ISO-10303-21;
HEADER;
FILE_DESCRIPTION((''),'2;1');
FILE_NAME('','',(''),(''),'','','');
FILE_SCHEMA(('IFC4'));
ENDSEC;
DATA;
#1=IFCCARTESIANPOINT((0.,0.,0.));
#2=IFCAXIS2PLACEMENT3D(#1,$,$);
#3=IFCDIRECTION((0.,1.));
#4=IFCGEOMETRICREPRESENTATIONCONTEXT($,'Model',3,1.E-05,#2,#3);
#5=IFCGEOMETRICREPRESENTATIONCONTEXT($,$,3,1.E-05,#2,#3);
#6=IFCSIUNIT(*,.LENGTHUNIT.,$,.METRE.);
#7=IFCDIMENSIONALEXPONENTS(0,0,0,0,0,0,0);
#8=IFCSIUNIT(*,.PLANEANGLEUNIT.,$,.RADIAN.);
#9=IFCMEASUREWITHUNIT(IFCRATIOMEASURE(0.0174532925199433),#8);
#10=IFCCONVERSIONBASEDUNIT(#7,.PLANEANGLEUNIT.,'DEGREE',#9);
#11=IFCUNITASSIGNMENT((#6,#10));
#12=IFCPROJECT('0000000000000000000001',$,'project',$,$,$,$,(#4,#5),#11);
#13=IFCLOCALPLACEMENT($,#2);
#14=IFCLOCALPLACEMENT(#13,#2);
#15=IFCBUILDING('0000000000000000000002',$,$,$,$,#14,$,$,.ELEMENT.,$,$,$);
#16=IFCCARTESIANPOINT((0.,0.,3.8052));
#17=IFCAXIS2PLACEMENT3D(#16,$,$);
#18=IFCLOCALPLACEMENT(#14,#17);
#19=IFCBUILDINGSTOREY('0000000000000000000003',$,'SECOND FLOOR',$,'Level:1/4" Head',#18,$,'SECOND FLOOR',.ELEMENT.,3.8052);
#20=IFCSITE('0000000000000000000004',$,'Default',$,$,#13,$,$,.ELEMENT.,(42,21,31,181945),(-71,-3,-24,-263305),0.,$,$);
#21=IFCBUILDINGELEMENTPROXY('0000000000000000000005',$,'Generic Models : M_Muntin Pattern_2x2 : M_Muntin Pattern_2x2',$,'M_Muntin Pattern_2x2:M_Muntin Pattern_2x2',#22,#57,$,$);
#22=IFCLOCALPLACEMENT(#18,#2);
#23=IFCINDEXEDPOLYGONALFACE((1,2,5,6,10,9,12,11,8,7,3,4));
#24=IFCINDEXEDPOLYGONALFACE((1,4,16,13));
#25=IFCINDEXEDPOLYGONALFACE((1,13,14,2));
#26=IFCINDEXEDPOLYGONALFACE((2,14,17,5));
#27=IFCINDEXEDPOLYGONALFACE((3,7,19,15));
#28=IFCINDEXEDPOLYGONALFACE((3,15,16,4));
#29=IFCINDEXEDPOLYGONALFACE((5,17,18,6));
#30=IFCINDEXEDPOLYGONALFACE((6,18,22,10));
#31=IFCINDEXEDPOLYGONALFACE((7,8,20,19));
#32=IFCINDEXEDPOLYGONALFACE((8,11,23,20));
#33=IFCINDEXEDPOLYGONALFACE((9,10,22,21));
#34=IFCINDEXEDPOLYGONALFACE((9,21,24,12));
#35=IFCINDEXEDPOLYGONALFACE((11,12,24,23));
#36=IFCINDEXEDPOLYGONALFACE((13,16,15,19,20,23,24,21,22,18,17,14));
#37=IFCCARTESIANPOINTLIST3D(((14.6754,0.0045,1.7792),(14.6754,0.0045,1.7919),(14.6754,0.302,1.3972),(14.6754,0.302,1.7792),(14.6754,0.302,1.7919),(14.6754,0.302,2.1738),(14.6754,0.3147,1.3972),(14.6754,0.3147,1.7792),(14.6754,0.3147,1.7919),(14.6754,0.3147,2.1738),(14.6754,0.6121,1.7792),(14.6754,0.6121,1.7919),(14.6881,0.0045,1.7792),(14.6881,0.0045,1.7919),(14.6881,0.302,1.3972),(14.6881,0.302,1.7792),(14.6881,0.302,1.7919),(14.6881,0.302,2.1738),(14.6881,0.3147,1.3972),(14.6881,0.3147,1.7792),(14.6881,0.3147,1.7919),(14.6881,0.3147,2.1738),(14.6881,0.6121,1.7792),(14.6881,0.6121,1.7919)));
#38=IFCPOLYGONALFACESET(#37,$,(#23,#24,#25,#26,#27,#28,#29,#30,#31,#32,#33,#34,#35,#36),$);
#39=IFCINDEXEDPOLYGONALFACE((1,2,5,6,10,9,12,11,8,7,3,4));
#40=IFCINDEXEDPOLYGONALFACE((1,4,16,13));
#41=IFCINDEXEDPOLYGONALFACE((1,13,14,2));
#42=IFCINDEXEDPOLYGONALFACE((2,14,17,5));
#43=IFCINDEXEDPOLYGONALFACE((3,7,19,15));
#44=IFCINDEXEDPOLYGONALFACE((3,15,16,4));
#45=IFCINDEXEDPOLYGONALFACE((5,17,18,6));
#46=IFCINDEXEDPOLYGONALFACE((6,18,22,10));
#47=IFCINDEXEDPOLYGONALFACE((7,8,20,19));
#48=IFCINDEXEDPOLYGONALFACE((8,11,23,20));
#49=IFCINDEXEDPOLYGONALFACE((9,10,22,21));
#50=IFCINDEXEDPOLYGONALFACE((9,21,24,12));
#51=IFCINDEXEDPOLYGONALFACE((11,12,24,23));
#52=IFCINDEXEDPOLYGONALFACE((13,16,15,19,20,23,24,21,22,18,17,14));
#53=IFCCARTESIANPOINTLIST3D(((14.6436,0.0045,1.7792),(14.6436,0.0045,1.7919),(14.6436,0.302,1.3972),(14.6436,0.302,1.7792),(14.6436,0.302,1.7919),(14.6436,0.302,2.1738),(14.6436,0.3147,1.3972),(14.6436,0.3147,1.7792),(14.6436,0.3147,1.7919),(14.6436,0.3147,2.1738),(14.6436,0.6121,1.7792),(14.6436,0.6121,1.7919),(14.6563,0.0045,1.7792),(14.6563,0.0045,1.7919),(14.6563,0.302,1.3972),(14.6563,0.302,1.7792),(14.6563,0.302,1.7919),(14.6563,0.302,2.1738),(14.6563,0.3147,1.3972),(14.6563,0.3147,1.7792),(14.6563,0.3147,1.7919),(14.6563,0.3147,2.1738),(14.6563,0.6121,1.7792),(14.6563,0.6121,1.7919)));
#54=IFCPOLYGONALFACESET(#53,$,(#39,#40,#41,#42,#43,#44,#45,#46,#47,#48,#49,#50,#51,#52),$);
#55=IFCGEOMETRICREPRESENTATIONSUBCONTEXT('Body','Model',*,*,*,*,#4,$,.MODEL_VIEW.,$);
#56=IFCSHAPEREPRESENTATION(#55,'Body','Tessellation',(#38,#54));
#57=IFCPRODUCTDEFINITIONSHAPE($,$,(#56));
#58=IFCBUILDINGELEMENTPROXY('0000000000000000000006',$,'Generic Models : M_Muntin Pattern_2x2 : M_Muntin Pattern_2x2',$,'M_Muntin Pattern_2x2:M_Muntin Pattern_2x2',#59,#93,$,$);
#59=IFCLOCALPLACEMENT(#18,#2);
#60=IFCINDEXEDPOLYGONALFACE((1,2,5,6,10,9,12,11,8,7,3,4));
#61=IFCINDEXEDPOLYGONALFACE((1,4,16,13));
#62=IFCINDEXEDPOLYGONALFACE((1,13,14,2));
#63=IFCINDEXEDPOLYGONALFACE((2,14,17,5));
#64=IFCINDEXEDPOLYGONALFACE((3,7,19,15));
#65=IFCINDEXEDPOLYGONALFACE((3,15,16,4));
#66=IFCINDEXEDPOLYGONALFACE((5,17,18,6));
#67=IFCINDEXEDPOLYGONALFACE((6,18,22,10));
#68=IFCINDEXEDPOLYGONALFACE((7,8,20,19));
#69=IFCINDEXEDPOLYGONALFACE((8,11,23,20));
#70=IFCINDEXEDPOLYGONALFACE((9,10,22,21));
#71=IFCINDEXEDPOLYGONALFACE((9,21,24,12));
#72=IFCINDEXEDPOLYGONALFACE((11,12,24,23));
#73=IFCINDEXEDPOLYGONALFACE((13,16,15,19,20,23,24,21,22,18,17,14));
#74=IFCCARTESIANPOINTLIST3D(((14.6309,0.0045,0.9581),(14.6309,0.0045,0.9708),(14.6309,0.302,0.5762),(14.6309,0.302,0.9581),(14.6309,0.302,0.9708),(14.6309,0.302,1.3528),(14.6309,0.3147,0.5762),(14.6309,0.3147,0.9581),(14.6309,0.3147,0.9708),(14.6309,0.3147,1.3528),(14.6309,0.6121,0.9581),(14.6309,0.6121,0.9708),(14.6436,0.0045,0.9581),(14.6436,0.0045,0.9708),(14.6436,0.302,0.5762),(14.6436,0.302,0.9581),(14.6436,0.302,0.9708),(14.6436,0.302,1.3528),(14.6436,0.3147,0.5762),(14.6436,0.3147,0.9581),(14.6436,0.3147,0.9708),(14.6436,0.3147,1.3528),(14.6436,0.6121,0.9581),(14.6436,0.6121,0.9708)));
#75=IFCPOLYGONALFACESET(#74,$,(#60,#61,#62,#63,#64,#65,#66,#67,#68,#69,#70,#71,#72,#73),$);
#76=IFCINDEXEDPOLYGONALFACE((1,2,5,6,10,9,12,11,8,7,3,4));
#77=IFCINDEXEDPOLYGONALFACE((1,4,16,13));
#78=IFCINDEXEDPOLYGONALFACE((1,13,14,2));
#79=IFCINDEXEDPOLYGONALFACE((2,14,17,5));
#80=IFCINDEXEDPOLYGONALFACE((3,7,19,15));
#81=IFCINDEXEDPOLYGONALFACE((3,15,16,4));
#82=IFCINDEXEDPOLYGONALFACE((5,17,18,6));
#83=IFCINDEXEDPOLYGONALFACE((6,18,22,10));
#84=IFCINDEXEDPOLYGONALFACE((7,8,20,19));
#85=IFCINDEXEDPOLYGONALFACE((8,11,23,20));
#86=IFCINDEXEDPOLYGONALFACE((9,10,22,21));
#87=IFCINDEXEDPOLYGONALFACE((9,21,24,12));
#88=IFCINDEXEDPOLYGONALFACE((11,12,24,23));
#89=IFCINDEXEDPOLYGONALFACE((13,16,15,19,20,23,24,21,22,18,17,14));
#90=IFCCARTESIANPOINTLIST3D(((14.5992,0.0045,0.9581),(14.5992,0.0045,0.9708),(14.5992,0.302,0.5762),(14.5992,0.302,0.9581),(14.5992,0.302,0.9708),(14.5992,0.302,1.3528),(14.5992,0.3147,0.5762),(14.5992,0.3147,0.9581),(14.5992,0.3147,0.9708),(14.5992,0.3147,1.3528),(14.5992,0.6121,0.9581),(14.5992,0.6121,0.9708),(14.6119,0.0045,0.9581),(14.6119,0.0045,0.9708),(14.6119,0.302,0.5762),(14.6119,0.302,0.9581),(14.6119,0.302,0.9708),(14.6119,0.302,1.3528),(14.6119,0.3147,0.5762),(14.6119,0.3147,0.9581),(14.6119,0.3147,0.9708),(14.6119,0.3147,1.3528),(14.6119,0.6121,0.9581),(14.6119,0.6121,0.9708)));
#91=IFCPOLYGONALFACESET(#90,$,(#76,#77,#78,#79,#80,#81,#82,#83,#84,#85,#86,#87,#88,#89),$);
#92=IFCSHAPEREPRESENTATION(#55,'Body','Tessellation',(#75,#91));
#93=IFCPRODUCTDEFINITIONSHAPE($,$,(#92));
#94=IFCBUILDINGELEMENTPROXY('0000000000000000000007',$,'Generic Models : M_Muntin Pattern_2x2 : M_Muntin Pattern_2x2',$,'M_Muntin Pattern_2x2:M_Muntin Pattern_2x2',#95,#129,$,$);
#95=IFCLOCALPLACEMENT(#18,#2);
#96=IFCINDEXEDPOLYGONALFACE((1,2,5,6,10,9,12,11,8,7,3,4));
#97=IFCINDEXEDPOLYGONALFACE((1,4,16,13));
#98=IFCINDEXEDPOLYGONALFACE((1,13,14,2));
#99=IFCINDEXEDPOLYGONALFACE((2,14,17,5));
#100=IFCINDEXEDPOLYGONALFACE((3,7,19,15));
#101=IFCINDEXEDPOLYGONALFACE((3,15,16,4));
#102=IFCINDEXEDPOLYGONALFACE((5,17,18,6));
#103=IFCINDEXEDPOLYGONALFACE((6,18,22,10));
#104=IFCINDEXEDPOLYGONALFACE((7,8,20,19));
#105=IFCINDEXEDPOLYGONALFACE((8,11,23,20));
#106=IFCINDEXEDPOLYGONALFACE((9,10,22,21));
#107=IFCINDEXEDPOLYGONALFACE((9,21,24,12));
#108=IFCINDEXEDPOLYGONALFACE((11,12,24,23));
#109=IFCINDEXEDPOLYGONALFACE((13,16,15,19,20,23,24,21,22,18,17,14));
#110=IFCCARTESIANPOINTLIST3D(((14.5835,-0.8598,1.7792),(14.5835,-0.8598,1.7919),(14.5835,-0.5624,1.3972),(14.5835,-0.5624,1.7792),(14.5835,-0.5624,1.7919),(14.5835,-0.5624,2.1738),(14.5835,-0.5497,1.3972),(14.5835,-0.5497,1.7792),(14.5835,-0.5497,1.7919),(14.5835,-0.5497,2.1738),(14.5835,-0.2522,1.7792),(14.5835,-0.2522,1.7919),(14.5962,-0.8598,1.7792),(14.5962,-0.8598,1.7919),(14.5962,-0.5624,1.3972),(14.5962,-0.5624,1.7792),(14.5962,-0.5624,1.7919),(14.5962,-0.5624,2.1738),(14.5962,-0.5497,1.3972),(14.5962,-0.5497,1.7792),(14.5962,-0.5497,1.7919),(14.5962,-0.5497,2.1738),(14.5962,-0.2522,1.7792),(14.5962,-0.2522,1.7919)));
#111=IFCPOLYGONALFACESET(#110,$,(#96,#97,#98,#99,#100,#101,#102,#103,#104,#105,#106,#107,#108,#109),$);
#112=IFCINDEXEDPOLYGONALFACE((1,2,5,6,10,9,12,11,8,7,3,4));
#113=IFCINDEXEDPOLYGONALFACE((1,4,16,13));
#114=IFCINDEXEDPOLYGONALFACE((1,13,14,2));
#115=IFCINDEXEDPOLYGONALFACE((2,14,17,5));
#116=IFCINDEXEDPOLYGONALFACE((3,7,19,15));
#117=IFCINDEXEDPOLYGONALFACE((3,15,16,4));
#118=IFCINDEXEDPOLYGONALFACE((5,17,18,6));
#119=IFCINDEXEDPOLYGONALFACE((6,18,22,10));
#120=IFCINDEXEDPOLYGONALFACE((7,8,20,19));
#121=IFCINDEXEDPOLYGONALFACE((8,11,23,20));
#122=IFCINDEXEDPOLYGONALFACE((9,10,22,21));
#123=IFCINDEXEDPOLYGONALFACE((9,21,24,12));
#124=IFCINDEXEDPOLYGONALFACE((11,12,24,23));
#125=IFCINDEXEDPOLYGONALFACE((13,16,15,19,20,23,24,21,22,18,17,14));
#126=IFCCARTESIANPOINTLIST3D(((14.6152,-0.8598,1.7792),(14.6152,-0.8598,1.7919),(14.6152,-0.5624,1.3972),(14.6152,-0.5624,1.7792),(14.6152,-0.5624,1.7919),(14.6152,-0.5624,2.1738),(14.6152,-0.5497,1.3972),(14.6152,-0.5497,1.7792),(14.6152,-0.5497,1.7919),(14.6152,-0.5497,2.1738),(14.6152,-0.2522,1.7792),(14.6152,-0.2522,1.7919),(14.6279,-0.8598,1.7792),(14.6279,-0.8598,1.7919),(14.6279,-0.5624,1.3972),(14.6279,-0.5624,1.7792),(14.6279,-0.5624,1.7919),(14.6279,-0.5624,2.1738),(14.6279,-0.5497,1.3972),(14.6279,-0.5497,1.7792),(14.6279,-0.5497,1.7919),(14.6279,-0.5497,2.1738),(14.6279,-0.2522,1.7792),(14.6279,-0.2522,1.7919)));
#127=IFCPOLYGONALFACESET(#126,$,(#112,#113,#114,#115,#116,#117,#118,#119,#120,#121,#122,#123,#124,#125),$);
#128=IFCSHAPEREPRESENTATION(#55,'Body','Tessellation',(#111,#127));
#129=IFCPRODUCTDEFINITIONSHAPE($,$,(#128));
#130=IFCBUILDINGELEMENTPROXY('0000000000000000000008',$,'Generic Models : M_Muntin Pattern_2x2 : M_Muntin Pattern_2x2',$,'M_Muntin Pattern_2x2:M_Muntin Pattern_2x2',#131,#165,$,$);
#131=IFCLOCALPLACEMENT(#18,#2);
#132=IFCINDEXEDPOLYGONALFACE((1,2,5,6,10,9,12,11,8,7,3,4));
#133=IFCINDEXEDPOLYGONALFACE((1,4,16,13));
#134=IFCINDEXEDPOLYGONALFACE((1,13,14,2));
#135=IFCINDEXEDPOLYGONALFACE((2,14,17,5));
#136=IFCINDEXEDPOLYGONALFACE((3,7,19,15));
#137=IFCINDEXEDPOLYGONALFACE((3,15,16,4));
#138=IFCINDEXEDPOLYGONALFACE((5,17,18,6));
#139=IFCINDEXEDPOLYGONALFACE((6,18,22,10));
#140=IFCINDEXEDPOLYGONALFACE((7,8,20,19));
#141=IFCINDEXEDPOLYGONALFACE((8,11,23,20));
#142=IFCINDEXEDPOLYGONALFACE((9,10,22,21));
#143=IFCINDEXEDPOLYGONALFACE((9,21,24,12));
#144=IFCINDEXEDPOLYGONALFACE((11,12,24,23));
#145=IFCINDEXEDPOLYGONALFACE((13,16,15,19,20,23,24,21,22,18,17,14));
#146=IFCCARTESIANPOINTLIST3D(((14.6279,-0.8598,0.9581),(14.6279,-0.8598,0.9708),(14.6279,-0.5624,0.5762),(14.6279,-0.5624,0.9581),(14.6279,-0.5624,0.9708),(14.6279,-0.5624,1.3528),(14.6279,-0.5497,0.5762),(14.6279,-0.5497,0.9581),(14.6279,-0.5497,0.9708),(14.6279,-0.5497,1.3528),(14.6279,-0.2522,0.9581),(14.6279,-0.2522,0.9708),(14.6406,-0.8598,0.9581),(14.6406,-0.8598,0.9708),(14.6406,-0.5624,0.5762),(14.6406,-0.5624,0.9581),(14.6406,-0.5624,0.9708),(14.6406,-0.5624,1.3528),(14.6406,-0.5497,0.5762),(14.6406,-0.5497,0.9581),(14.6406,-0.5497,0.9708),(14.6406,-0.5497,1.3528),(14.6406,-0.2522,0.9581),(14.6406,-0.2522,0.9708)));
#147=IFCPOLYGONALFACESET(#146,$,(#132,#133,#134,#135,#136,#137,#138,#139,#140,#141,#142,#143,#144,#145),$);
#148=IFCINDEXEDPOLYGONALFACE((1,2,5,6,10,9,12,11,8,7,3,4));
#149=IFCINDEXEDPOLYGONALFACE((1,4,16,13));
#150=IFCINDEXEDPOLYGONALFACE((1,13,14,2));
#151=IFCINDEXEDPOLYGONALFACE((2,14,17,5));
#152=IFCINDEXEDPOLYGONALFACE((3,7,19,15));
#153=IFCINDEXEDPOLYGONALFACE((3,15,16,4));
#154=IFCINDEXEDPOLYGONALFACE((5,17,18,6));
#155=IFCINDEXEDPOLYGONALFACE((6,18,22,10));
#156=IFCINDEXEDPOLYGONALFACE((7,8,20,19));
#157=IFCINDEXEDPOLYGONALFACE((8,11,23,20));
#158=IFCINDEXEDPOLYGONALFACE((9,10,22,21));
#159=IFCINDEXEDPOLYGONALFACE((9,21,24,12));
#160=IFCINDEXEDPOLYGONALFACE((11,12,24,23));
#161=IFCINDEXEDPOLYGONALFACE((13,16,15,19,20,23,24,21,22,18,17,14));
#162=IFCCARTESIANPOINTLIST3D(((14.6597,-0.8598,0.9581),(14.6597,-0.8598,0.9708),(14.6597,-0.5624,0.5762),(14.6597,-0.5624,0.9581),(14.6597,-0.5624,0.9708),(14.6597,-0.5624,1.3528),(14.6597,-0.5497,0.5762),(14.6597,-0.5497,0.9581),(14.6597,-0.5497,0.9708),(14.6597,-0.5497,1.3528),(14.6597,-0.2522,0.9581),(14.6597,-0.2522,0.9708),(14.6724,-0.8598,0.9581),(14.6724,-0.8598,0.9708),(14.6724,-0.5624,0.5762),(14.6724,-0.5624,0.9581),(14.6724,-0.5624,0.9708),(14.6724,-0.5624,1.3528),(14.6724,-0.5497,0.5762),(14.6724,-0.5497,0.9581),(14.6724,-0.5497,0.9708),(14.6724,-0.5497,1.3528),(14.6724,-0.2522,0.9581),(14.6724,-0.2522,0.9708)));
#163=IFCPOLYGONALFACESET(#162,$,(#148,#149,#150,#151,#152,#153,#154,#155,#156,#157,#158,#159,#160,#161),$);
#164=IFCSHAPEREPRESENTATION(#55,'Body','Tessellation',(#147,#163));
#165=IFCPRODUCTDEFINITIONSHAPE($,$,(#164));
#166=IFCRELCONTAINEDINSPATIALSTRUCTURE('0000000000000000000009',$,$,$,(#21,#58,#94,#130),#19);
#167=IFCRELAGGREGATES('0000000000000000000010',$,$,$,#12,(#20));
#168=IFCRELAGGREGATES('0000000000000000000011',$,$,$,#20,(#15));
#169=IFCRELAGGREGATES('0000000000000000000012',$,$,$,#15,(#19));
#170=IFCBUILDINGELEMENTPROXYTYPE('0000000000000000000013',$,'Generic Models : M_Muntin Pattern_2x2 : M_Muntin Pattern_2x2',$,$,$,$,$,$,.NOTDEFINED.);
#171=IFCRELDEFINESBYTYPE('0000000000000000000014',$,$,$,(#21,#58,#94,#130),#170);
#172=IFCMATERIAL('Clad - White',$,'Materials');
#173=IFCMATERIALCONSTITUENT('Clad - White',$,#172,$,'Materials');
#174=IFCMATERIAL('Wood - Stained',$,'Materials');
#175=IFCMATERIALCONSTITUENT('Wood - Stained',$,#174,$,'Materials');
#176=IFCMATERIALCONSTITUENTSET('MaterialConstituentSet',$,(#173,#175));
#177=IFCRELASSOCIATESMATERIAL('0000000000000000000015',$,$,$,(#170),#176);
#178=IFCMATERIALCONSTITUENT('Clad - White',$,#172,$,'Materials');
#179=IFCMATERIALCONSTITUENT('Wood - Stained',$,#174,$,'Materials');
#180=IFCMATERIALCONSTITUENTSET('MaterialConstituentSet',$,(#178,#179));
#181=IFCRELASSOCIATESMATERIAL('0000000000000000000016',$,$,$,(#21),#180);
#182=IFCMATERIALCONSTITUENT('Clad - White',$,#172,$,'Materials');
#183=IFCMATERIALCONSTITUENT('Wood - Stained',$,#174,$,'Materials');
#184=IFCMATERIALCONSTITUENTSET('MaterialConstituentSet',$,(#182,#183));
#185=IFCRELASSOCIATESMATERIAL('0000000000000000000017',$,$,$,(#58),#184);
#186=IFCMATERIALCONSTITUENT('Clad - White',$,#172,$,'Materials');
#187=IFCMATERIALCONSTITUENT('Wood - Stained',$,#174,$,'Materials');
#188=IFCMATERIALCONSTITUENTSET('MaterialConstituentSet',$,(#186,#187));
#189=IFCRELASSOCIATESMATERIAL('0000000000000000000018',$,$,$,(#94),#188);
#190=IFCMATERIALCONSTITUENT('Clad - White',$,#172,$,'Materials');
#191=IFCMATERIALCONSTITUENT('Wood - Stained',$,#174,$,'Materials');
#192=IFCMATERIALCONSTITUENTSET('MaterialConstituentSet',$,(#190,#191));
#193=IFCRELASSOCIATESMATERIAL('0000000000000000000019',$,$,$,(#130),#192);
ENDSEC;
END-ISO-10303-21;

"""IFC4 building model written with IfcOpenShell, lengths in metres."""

from ifc_helpers import new_model, entity, si_unit, converted_unit, direction, frame, origin, place, context, subcontext, project, spatial, polyline, outline, extrude, source, transform, mapped, material, constituent, constituent_set, type_object, type_shapes, element, save


model = new_model("IFC4")

# Units and contexts
model_context = context("Model", 3, precision=1e-05, world=origin(), true_north=direction((0.0, 1.0)))
context_of_model = context(None, 3, precision=1e-05, world=origin(), true_north=direction((0.0, 1.0)))
body_context = subcontext(model_context, "Body", "Model", "MODEL_VIEW")
ifc_project = project(units=[si_unit("LENGTHUNIT", "METRE"), converted_unit("PLANEANGLEUNIT", "DEGREE", entity("IfcRatioMeasure", 0.0174532925199433), si_unit("PLANEANGLEUNIT", "RADIAN"), dimensions=[0, 0, 0, 0, 0, 0, 0])], contexts=[model_context, context_of_model])

# Site, building, storey
site_placement = place(None, origin())
site = spatial("IfcSite", under=ifc_project, at=site_placement, Name="Default", CompositionType="ELEMENT", RefLatitude=(42, 21, 31, 181945), RefLongitude=(-71, -3, -24, -263305), RefElevation=0.0)
building_placement = place(site_placement, origin())
building = spatial("IfcBuilding", under=site, at=building_placement, CompositionType="ELEMENT")
storey_placement = place(building_placement, frame((0.0, 0.0, 3.8052)))
storey = spatial("IfcBuildingStorey", under=building, at=storey_placement, Name="SECOND FLOOR", ObjectType="Level:1/4\" Head", LongName="SECOND FLOOR", CompositionType="ELEMENT", Elevation=3.8052)

# Shared definitions
ifc_material_1 = material(Name="Wood - Stained", Category="Materials")

# Building element proxies
ifc_material_2 = material(Name="Clad - White", Category="Materials")
ifc_constituent_1 = constituent(ifc_material_2, Name="Clad - White", Category="Materials")
ifc_constituent_2 = constituent(ifc_material_1, Name="Wood - Stained", Category="Materials")
ifc_constituent_set_1 = constituent_set(constituents=[ifc_constituent_1, ifc_constituent_2], Name="MaterialConstituentSet")
ifc_constituent_3 = constituent(ifc_material_2, Name="Clad - White", Category="Materials")
ifc_constituent_4 = constituent(ifc_material_1, Name="Wood - Stained", Category="Materials")
ifc_constituent_set_2 = constituent_set(constituents=[ifc_constituent_3, ifc_constituent_4], Name="MaterialConstituentSet")
building_element_proxy_type_1 = type_object("IfcBuildingElementProxyType", Name="Generic Models : M_Muntin Pattern_2x2 : M_Muntin Pattern_2x2", PredefinedType="NOTDEFINED", material=ifc_constituent_set_2)
shared_shape_1 = source(origin(), body_context, "Body", "SweptSolid", [
    extrude(outline(polyline([(0.0064, -0.0064), (0.3883, -0.0064), (0.3883, 0.0063), (0.0064, 0.0063), (0.0064, 0.3038), (-0.0063, 0.3038), (-0.0063, 0.0063), (-0.3883, 0.0063), (-0.3883, -0.0064), (-0.0063, -0.0064), (-0.0063, -0.3038), (0.0064, -0.3038), (0.0064, -0.0064)])), frame((0.0, 0.0095, 0.3883), z_axis=(0.0, 1.0, 0.0), x_axis=(0.0, 0.0, 1.0)), (0.0, 0.0, 1.0), 0.0127),
    extrude(outline(polyline([(0.0064, -0.0064), (0.3883, -0.0064), (0.3883, 0.0063), (0.0064, 0.0063), (0.0064, 0.3038), (-0.0063, 0.3038), (-0.0063, 0.0063), (-0.3883, 0.0063), (-0.3883, -0.0064), (-0.0063, -0.0064), (-0.0063, -0.3038), (0.0064, -0.3038), (0.0064, -0.0064)])), frame((0.0, -0.0222, 0.3883), z_axis=(0.0, 1.0, 0.0), x_axis=(0.0, 0.0, 1.0)), (0.0, 0.0, 1.0), 0.0127),
])
type_shapes(building_element_proxy_type_1, [shared_shape_1])
proxy_1_placement = place(storey_placement, frame((14.6659, 0.3083, 1.3972), z_axis=(0.0, 0.0, 1.0), x_axis=(0.0, -1.0, 0.0)))
element("IfcBuildingElementProxy", 1, at=proxy_1_placement, inside=storey, type_object=building_element_proxy_type_1, material=ifc_constituent_set_1, Name="Generic Models : M_Muntin Pattern_2x2 : M_Muntin Pattern_2x2", ObjectType="M_Muntin Pattern_2x2:M_Muntin Pattern_2x2", context=body_context, shape_type="MappedRepresentation", body=[
    mapped(shared_shape_1, transform((0.0, 0.0, 0.0), scale=1.0)),
])
ifc_constituent_5 = constituent(ifc_material_2, Name="Clad - White", Category="Materials")
ifc_constituent_6 = constituent(ifc_material_1, Name="Wood - Stained", Category="Materials")
ifc_constituent_set_3 = constituent_set(constituents=[ifc_constituent_5, ifc_constituent_6], Name="MaterialConstituentSet")
proxy_2_placement = place(storey_placement, frame((14.6214, 0.3083, 0.5762), z_axis=(0.0, 0.0, 1.0), x_axis=(0.0, -1.0, 0.0)))
element("IfcBuildingElementProxy", 2, at=proxy_2_placement, inside=storey, type_object=building_element_proxy_type_1, material=ifc_constituent_set_3, Name="Generic Models : M_Muntin Pattern_2x2 : M_Muntin Pattern_2x2", ObjectType="M_Muntin Pattern_2x2:M_Muntin Pattern_2x2", context=body_context, shape_type="MappedRepresentation", body=[
    mapped(shared_shape_1, transform((0.0, 0.0, 0.0), scale=1.0)),
])
ifc_constituent_7 = constituent(ifc_material_2, Name="Clad - White", Category="Materials")
ifc_constituent_8 = constituent(ifc_material_1, Name="Wood - Stained", Category="Materials")
ifc_constituent_set_4 = constituent_set(constituents=[ifc_constituent_7, ifc_constituent_8], Name="MaterialConstituentSet")
proxy_3_placement = place(storey_placement, frame((14.6057, -0.556, 1.3972), z_axis=(0.0, 0.0, 1.0), x_axis=(0.0, 1.0, 0.0)))
element("IfcBuildingElementProxy", 3, at=proxy_3_placement, inside=storey, type_object=building_element_proxy_type_1, material=ifc_constituent_set_4, Name="Generic Models : M_Muntin Pattern_2x2 : M_Muntin Pattern_2x2", ObjectType="M_Muntin Pattern_2x2:M_Muntin Pattern_2x2", context=body_context, shape_type="MappedRepresentation", body=[
    mapped(shared_shape_1, transform((0.0, 0.0, 0.0), scale=1.0)),
])
ifc_constituent_9 = constituent(ifc_material_2, Name="Clad - White", Category="Materials")
ifc_constituent_10 = constituent(ifc_material_1, Name="Wood - Stained", Category="Materials")
ifc_constituent_set_5 = constituent_set(constituents=[ifc_constituent_9, ifc_constituent_10], Name="MaterialConstituentSet")
proxy_4_placement = place(storey_placement, frame((14.6502, -0.556, 0.5762), z_axis=(0.0, 0.0, 1.0), x_axis=(0.0, 1.0, 0.0)))
element("IfcBuildingElementProxy", 4, at=proxy_4_placement, inside=storey, type_object=building_element_proxy_type_1, material=ifc_constituent_set_5, Name="Generic Models : M_Muntin Pattern_2x2 : M_Muntin Pattern_2x2", ObjectType="M_Muntin Pattern_2x2:M_Muntin Pattern_2x2", context=body_context, shape_type="MappedRepresentation", body=[
    mapped(shared_shape_1, transform((0.0, 0.0, 0.0), scale=1.0)),
])

save(model, "model.ifc")
